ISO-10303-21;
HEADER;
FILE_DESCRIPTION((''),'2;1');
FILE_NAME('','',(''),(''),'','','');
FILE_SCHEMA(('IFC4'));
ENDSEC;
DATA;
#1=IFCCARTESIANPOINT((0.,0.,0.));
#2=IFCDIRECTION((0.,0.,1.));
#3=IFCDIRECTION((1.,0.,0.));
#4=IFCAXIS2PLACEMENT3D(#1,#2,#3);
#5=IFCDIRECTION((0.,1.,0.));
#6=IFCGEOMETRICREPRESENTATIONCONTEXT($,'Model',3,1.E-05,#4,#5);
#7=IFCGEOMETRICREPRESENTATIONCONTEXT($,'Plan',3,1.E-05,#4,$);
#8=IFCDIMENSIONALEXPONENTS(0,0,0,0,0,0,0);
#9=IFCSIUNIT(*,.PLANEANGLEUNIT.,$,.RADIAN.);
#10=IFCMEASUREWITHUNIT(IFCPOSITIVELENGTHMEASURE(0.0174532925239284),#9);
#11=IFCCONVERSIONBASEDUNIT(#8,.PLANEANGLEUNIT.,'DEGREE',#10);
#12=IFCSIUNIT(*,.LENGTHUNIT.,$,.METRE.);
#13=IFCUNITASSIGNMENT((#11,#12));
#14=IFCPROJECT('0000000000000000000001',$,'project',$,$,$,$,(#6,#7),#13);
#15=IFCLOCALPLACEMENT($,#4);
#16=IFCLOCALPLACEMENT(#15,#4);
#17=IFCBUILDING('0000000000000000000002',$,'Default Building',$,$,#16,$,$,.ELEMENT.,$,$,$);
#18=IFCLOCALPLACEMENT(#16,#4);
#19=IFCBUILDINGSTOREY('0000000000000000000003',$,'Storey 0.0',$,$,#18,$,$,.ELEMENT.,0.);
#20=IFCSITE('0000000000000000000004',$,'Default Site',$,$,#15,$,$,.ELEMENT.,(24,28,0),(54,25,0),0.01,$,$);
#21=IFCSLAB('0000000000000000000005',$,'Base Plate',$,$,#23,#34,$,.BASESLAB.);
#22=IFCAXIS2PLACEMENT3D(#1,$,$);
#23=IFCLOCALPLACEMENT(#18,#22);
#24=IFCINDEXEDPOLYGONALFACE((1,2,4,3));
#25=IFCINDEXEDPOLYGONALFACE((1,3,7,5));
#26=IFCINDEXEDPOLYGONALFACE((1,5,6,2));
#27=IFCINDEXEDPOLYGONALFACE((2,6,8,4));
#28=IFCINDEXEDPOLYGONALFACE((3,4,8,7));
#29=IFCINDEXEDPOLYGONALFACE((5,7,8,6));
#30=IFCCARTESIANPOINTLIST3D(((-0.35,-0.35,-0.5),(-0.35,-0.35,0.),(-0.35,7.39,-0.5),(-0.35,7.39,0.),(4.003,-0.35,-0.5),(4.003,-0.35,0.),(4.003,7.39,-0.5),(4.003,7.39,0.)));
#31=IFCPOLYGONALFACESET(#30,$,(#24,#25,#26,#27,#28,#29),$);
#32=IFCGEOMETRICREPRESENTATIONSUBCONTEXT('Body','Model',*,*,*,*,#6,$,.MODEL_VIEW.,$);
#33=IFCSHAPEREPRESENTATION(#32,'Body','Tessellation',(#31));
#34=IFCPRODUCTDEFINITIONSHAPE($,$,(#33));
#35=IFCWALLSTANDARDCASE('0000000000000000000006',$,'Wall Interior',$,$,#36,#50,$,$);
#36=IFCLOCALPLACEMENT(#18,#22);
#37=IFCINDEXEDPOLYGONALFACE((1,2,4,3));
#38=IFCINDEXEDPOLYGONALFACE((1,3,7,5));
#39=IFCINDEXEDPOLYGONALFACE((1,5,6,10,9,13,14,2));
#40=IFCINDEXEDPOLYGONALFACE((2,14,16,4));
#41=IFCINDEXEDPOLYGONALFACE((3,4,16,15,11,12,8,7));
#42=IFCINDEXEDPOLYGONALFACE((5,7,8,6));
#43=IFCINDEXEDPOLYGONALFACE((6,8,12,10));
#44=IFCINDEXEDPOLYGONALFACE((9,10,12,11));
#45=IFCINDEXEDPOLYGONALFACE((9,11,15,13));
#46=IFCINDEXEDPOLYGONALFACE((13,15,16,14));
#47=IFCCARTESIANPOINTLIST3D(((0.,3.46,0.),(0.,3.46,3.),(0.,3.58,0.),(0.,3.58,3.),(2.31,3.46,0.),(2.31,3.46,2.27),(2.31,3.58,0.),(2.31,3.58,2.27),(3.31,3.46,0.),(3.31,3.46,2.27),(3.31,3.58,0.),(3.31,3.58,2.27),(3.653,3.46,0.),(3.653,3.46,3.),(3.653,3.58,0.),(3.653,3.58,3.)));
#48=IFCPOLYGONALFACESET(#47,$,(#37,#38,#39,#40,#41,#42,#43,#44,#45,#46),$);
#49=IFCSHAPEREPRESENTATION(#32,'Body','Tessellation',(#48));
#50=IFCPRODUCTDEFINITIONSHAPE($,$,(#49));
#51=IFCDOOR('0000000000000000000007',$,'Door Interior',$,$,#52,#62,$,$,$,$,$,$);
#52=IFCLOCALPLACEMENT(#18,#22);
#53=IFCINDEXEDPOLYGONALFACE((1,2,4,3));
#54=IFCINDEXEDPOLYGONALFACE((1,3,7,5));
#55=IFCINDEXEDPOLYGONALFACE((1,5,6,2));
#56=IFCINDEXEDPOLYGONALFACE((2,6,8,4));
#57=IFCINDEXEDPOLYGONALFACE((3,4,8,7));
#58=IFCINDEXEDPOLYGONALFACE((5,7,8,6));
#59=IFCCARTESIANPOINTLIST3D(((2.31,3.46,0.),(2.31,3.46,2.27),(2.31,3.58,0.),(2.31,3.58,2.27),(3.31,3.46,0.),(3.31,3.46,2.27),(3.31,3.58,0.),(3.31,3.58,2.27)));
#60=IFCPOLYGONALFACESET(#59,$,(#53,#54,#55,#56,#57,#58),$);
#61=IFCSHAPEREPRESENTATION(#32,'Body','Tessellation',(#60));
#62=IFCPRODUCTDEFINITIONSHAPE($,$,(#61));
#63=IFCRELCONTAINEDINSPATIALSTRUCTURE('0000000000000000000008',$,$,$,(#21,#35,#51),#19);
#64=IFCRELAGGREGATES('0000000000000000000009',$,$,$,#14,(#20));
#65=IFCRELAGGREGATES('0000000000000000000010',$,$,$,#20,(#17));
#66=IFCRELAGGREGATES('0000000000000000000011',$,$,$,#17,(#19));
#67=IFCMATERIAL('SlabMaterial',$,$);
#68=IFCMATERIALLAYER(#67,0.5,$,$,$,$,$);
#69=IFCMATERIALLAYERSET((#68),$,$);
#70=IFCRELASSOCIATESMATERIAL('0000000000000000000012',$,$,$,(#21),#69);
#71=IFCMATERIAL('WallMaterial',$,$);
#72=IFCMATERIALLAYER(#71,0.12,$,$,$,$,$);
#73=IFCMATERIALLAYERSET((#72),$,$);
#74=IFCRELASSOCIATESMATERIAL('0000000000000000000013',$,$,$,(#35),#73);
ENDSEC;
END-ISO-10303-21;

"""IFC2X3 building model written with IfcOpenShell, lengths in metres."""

from ifc_helpers import new_model, entity, si_unit, converted_unit, direction, frame, origin_with_axes, place, context, subcontext, project, spatial, polyline, outline, extrude, material, layer, layer_set, layer_usage, element, fill, save


model = new_model("IFC2X3")

# Units and contexts
model_context = context("Model", 3, precision=1e-05, world=origin_with_axes(), true_north=direction((0.0, 1.0, 0.0)))
plan_context = context("Plan", 3, precision=1e-05, world=origin_with_axes())
body_context = subcontext(model_context, "Body", "Model", "MODEL_VIEW")
ifc_project = project(units=[converted_unit("PLANEANGLEUNIT", "DEGREE", entity("IfcPositiveLengthMeasure", 0.0174532925239284), si_unit("PLANEANGLEUNIT", "RADIAN"), dimensions=[0, 0, 0, 0, 0, 0, 0]), si_unit("LENGTHUNIT", "METRE")], contexts=[model_context, plan_context])

# Site, building, storey
site_placement = place(None, origin_with_axes())
site = spatial("IfcSite", under=ifc_project, at=site_placement, Name="Default Site", CompositionType="ELEMENT", RefLatitude=(24, 28, 0), RefLongitude=(54, 25, 0), RefElevation=0.01)
building_placement = place(site_placement, origin_with_axes())
building = spatial("IfcBuilding", under=site, at=building_placement, Name="Default Building", CompositionType="ELEMENT")
storey_placement = place(building_placement, origin_with_axes())
storey = spatial("IfcBuildingStorey", under=building, at=storey_placement, Name="Storey 0.0", CompositionType="ELEMENT", Elevation=0.0)

# Slab
ifc_material_1 = material(Name="SlabMaterial")
ifc_layer_1 = layer(ifc_material_1, 0.5)
ifc_layer_set_1 = layer_set([ifc_layer_1])
ifc_layer_usage_1 = layer_usage(ifc_layer_set_1, "AXIS2", "POSITIVE", 0.5)
slab_placement = place(storey_placement, frame((0.0, 0.0, -0.5), z_axis=(0.0, 0.0, 1.0), x_axis=(1.0, 0.0, 0.0)))
element("IfcSlab", 1, at=slab_placement, inside=storey, material=ifc_layer_usage_1, Name="Base Plate", PredefinedType="BASESLAB", context=body_context, shape_type="SweptSolid", body=[
    extrude(outline(polyline([(4.003, 7.39), (-0.35, 7.39), (-0.35, -0.35), (4.003, -0.35), (4.003, 7.39)])), origin_with_axes(), (0.0, 0.0, 1.0), 0.5),
])

# Wall, opening, door
ifc_material_2 = material(Name="WallMaterial")
ifc_layer_2 = layer(ifc_material_2, 0.12)
ifc_layer_set_2 = layer_set([ifc_layer_2])
ifc_layer_usage_2 = layer_usage(ifc_layer_set_2, "AXIS2", "POSITIVE", -0.06)
wall_1_placement = place(storey_placement, frame((3.653, 3.52, 0.0), z_axis=(0.0, 0.0, 1.0), x_axis=(-1.0, 0.0, 0.0)))
wall_1 = element("IfcWallStandardCase", 2, at=wall_1_placement, inside=storey, material=ifc_layer_usage_2, Name="Wall Interior", context=body_context, shape_type="SweptSolid", body=[
    extrude(outline(polyline([(0.0, -0.06), (3.653, -0.06), (3.653, 0.06), (0.0, 0.06), (0.0, -0.06)])), origin_with_axes(), (0.0, 0.0, 1.0), 3.0),
])
opening_1_placement = place(wall_1_placement, frame((0.843, 0.0, 0.0), z_axis=(0.0, 0.0, 1.0), x_axis=(1.0, 0.0, 0.0)))
opening_1 = element("IfcOpeningElement", 3, at=opening_1_placement, cuts=wall_1, context=body_context, shape_type="SweptSolid", body=[
    extrude(outline(polyline([(-0.5, 0.142), (0.5, 0.142), (0.5, -0.142), (-0.5, -0.142), (-0.5, 0.142)])), origin_with_axes(), (0.0, 0.0, 1.0), 2.27),
])
door_1_placement = place(opening_1_placement, origin_with_axes())
door_1 = element("IfcDoor", 4, at=door_1_placement, inside=storey, Name="Door Interior", context=body_context, shape_type="SweptSolid", body=[
    extrude(outline(polyline([(-0.5, 0.06), (0.5, 0.06), (0.5, -0.06), (-0.5, -0.06), (-0.5, 0.06)])), origin_with_axes(), (0.0, 0.0, 1.0), 2.27),
])
fill(opening_1, door_1)

save(model, "model.ifc")
